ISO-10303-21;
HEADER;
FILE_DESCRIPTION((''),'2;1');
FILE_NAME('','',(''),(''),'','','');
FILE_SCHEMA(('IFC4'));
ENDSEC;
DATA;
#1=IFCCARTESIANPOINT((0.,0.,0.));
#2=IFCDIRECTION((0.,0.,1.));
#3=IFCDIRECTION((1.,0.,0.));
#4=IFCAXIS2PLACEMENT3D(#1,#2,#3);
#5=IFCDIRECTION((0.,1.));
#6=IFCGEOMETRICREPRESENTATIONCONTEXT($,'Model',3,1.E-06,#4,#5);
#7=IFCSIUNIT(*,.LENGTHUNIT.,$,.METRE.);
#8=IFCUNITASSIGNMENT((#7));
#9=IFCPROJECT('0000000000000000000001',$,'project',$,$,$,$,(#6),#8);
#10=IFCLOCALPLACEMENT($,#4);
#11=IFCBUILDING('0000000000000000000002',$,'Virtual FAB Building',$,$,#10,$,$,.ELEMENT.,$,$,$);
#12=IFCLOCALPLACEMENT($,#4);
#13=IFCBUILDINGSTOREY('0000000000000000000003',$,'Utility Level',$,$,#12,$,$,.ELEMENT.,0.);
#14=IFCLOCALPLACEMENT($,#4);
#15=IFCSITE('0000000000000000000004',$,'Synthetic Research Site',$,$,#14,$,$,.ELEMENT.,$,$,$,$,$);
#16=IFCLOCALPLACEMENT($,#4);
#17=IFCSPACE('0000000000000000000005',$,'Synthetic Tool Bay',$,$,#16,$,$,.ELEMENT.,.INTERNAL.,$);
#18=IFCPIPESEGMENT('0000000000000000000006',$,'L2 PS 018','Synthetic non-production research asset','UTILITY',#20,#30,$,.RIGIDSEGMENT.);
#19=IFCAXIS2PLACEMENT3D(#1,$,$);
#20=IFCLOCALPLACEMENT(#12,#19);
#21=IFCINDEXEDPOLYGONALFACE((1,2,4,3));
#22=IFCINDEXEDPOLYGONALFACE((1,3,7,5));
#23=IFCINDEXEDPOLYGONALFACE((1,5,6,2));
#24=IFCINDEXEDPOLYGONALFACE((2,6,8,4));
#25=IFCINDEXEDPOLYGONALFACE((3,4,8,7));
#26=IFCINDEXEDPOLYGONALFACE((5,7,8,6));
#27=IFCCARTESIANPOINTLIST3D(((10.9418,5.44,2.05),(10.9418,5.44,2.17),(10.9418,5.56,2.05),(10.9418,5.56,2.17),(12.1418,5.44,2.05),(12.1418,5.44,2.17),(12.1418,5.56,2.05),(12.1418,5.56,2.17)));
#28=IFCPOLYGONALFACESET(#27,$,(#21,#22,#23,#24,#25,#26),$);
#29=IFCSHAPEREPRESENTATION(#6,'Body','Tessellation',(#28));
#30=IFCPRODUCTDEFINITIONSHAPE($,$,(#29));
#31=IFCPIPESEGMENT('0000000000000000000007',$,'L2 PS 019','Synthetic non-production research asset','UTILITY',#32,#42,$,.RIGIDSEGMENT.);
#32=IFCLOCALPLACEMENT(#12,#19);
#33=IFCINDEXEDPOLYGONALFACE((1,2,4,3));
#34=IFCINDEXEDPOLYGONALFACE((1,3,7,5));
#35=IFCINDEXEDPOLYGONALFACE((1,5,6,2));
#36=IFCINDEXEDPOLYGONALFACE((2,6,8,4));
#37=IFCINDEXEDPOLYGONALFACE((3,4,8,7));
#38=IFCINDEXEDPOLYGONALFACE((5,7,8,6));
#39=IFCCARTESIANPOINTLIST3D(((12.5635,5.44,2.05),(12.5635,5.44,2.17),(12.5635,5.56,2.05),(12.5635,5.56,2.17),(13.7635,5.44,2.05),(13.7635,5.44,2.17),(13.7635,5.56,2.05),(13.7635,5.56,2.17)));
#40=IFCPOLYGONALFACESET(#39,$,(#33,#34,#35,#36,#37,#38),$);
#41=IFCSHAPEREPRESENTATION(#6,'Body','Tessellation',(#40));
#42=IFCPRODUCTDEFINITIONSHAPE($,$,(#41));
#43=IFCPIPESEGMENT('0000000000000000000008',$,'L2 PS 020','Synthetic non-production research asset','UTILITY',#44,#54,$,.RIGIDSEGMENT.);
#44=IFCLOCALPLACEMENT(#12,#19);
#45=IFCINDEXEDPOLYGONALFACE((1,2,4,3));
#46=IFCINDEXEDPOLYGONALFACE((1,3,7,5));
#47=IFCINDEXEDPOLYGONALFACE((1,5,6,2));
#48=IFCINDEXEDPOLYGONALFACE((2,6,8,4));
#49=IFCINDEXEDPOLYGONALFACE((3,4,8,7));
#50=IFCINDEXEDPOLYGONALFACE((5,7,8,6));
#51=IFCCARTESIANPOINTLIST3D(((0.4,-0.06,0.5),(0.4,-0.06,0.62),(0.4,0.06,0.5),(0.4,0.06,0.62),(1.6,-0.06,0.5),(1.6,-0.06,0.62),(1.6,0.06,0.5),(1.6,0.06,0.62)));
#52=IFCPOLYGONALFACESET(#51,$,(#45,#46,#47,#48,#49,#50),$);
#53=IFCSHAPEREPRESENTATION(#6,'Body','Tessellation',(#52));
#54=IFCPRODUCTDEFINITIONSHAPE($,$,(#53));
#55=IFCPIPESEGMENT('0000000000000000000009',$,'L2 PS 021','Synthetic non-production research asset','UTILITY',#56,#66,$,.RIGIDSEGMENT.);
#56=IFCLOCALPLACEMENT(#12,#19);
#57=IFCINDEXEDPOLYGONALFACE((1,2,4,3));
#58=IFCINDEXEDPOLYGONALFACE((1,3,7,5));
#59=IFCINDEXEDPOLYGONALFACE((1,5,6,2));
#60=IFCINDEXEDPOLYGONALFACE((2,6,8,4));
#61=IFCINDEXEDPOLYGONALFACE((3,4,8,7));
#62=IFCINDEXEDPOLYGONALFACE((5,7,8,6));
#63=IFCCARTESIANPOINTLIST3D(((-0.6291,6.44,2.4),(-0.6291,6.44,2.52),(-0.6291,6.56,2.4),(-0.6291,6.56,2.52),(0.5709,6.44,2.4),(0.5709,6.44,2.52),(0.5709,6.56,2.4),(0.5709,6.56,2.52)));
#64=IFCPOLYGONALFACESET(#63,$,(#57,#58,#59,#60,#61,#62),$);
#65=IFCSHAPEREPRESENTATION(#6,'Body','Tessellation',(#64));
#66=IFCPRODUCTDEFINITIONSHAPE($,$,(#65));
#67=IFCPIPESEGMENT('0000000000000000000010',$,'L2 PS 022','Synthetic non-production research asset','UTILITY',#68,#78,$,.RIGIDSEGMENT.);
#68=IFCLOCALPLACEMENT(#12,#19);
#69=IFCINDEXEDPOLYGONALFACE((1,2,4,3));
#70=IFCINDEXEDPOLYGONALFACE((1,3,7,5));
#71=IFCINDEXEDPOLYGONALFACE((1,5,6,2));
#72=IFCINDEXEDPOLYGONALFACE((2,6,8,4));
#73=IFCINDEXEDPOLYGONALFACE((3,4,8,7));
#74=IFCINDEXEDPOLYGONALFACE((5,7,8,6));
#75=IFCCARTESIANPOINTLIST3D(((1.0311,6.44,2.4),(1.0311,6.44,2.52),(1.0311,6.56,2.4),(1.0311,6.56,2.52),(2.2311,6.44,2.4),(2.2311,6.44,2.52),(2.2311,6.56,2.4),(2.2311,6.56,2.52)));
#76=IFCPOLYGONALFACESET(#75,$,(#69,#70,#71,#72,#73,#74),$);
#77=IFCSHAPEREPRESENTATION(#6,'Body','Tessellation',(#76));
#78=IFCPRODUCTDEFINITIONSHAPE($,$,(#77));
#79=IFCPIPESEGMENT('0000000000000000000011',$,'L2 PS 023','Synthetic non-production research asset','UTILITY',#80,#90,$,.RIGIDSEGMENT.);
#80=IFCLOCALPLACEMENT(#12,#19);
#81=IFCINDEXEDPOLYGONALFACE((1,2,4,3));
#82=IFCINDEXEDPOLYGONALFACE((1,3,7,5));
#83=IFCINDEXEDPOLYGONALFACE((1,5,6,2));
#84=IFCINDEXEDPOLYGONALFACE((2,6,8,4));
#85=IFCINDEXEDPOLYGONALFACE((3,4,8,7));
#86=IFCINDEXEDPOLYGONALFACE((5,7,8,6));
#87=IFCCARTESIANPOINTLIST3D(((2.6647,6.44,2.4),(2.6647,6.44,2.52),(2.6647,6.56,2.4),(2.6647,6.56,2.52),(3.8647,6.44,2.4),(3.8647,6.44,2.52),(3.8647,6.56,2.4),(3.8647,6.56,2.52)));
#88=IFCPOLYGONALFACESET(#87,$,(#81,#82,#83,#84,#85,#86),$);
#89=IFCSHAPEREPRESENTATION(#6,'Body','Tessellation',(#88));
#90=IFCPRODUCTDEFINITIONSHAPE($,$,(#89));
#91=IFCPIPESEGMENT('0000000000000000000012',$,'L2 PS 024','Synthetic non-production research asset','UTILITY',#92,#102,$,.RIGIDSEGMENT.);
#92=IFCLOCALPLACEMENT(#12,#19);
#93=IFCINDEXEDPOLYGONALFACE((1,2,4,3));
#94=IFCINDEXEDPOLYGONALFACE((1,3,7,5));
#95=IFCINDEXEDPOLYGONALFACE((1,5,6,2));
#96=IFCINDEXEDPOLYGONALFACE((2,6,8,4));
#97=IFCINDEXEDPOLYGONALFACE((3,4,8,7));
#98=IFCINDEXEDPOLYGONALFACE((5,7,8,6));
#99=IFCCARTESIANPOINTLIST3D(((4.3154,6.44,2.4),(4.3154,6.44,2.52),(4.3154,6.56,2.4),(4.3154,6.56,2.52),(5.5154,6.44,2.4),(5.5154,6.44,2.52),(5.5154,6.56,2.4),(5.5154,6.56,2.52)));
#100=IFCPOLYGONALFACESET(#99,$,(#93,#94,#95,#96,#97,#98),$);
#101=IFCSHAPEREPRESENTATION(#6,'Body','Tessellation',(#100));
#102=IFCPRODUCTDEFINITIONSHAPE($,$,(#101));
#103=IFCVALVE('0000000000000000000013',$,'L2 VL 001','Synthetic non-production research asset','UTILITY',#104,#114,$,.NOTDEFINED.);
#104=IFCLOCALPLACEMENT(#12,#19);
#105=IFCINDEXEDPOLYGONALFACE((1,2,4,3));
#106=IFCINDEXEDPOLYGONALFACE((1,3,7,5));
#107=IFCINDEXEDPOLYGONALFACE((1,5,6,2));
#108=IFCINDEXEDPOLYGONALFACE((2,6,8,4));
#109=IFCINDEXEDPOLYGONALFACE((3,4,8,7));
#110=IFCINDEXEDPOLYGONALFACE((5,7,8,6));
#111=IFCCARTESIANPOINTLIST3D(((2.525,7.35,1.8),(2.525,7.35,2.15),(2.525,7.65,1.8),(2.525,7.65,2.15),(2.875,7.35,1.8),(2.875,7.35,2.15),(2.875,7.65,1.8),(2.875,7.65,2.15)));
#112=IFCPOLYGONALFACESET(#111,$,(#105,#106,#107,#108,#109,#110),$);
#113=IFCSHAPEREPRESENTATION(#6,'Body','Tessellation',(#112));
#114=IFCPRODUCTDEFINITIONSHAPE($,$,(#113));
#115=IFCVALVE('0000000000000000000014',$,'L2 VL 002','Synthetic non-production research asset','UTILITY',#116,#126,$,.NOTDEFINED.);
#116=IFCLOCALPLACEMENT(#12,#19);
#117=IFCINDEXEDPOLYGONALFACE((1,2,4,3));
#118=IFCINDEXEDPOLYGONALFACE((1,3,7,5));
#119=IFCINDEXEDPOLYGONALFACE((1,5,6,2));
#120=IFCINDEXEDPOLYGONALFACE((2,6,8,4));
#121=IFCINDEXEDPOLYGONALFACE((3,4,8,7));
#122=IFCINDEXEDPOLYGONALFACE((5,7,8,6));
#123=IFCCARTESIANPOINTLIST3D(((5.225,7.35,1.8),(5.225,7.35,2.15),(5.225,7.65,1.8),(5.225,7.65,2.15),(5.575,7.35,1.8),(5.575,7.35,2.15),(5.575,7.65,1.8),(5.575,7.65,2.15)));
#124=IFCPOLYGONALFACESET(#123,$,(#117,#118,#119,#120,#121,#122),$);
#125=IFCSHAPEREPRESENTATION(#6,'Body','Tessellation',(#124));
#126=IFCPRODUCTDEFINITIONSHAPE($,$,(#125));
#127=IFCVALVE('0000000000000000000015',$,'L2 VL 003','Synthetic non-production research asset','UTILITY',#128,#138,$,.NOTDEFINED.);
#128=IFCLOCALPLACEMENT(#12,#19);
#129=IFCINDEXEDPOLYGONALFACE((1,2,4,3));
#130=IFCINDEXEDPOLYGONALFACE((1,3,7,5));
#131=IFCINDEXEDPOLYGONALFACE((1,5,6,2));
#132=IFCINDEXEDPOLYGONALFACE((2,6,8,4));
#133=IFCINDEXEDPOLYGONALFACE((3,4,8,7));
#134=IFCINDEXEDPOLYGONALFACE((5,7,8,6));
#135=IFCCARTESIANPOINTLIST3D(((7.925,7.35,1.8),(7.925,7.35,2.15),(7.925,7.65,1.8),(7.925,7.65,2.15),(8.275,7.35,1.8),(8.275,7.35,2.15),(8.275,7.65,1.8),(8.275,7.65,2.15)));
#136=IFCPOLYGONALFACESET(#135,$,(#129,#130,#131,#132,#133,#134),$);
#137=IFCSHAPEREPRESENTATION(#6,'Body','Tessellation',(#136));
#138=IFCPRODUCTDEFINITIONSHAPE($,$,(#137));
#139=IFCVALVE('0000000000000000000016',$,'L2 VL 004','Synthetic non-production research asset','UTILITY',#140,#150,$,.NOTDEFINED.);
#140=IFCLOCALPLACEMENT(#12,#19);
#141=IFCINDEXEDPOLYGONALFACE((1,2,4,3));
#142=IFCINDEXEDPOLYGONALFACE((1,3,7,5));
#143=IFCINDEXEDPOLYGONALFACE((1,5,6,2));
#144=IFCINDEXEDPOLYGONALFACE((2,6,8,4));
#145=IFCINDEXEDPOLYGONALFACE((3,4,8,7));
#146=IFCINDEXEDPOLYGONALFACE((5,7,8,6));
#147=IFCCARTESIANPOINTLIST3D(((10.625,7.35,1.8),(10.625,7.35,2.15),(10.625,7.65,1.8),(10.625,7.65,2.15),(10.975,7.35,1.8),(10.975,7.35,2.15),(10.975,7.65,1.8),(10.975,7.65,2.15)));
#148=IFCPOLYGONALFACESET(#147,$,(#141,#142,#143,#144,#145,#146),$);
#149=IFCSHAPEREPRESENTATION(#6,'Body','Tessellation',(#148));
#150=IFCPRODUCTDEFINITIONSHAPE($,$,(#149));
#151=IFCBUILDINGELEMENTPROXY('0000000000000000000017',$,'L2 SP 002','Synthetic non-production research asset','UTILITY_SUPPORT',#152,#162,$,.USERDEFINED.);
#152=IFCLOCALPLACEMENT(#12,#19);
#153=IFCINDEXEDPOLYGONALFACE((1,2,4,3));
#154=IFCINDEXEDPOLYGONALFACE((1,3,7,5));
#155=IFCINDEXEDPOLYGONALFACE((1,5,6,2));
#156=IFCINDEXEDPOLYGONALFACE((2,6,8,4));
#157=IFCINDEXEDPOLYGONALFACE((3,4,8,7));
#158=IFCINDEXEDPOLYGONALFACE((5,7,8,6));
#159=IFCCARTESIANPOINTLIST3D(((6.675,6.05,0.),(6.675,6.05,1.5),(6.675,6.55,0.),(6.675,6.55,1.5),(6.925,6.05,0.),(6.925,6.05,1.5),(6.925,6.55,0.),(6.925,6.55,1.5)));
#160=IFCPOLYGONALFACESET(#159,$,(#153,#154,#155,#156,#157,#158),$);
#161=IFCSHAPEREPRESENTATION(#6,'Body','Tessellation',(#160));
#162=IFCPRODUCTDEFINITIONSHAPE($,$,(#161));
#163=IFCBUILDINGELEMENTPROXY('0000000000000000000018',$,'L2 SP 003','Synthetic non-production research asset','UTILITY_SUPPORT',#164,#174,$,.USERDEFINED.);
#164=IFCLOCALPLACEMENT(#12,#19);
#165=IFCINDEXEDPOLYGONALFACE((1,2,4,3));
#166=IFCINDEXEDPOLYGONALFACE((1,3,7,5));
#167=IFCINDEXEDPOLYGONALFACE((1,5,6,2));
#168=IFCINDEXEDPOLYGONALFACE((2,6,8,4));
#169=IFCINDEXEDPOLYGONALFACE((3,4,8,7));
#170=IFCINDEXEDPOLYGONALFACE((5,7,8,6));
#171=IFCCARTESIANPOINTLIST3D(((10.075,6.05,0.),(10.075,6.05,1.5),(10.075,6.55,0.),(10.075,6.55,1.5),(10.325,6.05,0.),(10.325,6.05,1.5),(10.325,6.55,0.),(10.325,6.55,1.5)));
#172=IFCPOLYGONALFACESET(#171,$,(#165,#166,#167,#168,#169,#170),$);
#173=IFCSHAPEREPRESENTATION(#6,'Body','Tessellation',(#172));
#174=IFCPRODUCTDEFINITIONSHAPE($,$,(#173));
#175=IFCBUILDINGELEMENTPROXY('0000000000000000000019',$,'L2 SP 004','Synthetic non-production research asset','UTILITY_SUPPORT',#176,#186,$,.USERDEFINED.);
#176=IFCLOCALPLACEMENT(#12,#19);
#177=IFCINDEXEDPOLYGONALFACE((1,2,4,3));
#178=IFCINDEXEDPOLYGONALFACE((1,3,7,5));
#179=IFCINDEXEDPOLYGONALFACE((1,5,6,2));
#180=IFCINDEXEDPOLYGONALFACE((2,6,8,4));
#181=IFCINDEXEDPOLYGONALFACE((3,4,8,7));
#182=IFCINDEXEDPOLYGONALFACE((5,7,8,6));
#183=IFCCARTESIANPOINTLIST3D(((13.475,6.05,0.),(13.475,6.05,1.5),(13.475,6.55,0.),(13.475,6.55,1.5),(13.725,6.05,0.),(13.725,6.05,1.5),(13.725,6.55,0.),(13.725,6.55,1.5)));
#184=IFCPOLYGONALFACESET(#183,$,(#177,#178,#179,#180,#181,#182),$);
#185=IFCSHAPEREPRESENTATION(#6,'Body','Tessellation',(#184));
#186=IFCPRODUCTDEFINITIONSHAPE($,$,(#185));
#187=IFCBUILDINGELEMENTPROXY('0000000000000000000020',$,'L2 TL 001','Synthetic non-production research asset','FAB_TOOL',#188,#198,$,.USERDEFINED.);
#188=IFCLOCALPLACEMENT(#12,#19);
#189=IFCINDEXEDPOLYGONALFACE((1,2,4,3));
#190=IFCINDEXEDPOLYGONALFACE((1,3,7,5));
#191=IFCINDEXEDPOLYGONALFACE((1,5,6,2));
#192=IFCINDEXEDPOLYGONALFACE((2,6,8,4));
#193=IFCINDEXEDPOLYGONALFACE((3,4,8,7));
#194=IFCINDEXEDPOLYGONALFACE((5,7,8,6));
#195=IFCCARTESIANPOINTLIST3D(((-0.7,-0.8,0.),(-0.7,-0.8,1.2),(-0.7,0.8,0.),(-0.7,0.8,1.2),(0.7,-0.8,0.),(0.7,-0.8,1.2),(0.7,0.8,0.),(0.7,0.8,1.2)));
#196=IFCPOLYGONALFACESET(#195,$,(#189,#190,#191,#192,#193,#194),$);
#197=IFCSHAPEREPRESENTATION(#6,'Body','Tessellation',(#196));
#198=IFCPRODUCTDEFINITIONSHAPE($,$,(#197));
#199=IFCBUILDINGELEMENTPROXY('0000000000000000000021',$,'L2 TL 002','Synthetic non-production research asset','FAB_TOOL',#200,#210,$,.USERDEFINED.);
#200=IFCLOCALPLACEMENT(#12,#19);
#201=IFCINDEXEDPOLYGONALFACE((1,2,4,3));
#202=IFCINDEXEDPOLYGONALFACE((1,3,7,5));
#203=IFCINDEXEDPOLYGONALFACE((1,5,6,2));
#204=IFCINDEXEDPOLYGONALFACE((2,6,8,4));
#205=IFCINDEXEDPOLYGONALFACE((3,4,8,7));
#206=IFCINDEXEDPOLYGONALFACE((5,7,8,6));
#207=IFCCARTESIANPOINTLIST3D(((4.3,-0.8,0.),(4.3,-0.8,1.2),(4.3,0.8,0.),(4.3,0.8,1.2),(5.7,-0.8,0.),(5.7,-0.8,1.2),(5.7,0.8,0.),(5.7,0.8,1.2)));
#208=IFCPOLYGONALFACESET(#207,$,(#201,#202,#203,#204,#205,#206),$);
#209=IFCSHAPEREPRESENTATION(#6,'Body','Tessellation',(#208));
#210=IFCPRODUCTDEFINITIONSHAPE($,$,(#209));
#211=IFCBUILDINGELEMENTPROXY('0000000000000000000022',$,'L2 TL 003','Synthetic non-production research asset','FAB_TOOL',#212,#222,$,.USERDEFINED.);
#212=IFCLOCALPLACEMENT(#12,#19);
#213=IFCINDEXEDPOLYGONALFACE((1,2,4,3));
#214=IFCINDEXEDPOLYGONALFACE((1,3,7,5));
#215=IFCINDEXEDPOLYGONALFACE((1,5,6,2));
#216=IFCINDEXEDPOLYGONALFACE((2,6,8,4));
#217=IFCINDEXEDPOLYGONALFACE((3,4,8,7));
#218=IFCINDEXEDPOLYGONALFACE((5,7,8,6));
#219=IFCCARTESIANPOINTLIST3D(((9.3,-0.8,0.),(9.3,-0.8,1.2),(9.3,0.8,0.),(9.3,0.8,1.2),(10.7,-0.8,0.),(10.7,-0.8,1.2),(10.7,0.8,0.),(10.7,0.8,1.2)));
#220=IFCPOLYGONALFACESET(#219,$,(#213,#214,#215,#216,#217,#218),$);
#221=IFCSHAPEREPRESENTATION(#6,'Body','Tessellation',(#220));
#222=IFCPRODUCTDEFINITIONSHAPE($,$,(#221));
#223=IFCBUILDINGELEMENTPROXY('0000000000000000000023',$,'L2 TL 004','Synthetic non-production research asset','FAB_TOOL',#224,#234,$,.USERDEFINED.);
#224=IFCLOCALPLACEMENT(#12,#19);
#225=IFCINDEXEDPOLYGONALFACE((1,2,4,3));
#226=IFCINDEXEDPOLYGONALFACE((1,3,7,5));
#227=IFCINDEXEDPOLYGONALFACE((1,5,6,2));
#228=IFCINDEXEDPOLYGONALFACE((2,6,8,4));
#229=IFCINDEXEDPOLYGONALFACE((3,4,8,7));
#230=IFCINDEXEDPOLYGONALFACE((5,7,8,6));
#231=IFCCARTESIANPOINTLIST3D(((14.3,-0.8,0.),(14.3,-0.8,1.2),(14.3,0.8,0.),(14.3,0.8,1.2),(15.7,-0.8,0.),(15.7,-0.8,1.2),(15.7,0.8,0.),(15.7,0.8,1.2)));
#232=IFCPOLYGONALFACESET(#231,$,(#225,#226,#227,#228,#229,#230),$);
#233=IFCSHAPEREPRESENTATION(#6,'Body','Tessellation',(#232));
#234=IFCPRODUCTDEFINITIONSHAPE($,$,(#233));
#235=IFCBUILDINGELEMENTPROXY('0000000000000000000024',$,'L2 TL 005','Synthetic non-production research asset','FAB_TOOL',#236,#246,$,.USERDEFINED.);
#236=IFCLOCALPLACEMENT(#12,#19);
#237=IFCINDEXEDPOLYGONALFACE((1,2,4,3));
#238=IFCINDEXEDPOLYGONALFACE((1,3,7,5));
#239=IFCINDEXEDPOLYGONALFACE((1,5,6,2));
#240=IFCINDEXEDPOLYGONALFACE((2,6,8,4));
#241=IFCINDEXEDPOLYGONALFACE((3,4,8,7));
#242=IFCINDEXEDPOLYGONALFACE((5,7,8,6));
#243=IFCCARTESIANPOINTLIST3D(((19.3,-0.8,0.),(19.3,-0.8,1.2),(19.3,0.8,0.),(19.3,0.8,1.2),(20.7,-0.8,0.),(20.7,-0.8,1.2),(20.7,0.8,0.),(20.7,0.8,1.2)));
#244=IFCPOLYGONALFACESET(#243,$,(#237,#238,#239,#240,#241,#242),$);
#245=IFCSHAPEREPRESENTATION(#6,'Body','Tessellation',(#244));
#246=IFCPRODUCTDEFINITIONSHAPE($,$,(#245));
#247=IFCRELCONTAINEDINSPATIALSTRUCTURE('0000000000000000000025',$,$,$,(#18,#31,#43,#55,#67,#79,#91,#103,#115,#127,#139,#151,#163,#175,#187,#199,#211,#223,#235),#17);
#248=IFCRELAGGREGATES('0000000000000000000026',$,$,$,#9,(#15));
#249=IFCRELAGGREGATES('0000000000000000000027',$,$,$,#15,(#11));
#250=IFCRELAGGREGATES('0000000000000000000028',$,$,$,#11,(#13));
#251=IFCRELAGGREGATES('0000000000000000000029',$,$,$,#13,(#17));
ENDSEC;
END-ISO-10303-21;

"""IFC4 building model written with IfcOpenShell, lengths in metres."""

from ifc_helpers import new_model, si_unit, direction, frame, origin_with_axes, origin_2d_with_axis, place, context, project, spatial, rectangle, extrude, element, save


model = new_model("IFC4")

# Units and contexts
model_context = context("Model", 3, precision=1e-06, world=origin_with_axes(), true_north=direction((0.0, 1.0)))
ifc_project = project(units=[si_unit("LENGTHUNIT", "METRE")], contexts=[model_context])

# Site, building, storey, space
site_placement = place(None, origin_with_axes())
site = spatial("IfcSite", under=ifc_project, at=site_placement, Name="Synthetic Research Site", CompositionType="ELEMENT")
building_placement = place(None, origin_with_axes())
building = spatial("IfcBuilding", under=site, at=building_placement, Name="Virtual FAB Building", CompositionType="ELEMENT")
storey_placement = place(None, origin_with_axes())
storey = spatial("IfcBuildingStorey", under=building, at=storey_placement, Name="Utility Level", CompositionType="ELEMENT", Elevation=0.0)
space_placement = place(None, origin_with_axes())
space = spatial("IfcSpace", under=storey, at=space_placement, Name="Synthetic Tool Bay", CompositionType="ELEMENT", PredefinedType="INTERNAL")

# Pipe segments
for number, where, z_axis, x_axis, name in (
    (1, (11.5418, 5.5, 2.05), (0.0, 0.0, 1.0), (1.0, 0.0, 0.0), "L2 PS 018"),
    (2, (13.1635, 5.5, 2.05), (0.0, 0.0, 1.0), (1.0, 0.0, 0.0), "L2 PS 019"),
    (3, (1.0, 0.0, 0.5), (0.0, 0.0, 1.0), (1.0, 0.0, 0.0), "L2 PS 020"),
    (4, (-0.0291, 6.5, 2.4), (0.0, 0.0, 1.0), (1.0, 0.0, 0.0), "L2 PS 021"),
    (5, (1.6311, 6.5, 2.4), (0.0, 0.0, 1.0), (1.0, 0.0, 0.0), "L2 PS 022"),
    (6, (3.2647, 6.5, 2.4), (0.0, 0.0, 1.0), (1.0, 0.0, 0.0), "L2 PS 023"),
    (7, (4.9154, 6.5, 2.4), (0.0, 0.0, 1.0), (1.0, 0.0, 0.0), "L2 PS 024"),
):
    element("IfcPipeSegment", number, at=place(None, frame(where, z_axis=z_axis, x_axis=x_axis)), inside=space, Name=name, Description="Synthetic non-production research asset", ObjectType="UTILITY", PredefinedType="RIGIDSEGMENT", context=model_context, shape_type="SweptSolid", body=[
        extrude(rectangle(XDim=1.2, YDim=0.12, at=origin_2d_with_axis()), origin_with_axes(), (0.0, 0.0, 1.0), 0.12),
    ])

# Valves
for number, where, z_axis, x_axis, name in (
    (8, (2.7, 7.5, 1.8), (0.0, 0.0, 1.0), (1.0, 0.0, 0.0), "L2 VL 001"),
    (9, (5.4, 7.5, 1.8), (0.0, 0.0, 1.0), (1.0, 0.0, 0.0), "L2 VL 002"),
    (10, (8.1, 7.5, 1.8), (0.0, 0.0, 1.0), (1.0, 0.0, 0.0), "L2 VL 003"),
    (11, (10.8, 7.5, 1.8), (0.0, 0.0, 1.0), (1.0, 0.0, 0.0), "L2 VL 004"),
):
    element("IfcValve", number, at=place(None, frame(where, z_axis=z_axis, x_axis=x_axis)), inside=space, Name=name, Description="Synthetic non-production research asset", ObjectType="UTILITY", PredefinedType="NOTDEFINED", context=model_context, shape_type="SweptSolid", body=[
        extrude(rectangle(XDim=0.35, YDim=0.3, at=origin_2d_with_axis()), origin_with_axes(), (0.0, 0.0, 1.0), 0.35),
    ])

# Building element proxies
for number, where, z_axis, x_axis, name in (
    (12, (6.8, 6.3, 0.0), (0.0, 0.0, 1.0), (1.0, 0.0, 0.0), "L2 SP 002"),
    (13, (10.2, 6.3, 0.0), (0.0, 0.0, 1.0), (1.0, 0.0, 0.0), "L2 SP 003"),
    (14, (13.6, 6.3, 0.0), (0.0, 0.0, 1.0), (1.0, 0.0, 0.0), "L2 SP 004"),
):
    element("IfcBuildingElementProxy", number, at=place(None, frame(where, z_axis=z_axis, x_axis=x_axis)), inside=space, Name=name, Description="Synthetic non-production research asset", ObjectType="UTILITY_SUPPORT", PredefinedType="USERDEFINED", context=model_context, shape_type="SweptSolid", body=[
        extrude(rectangle(XDim=0.25, YDim=0.5, at=origin_2d_with_axis()), origin_with_axes(), (0.0, 0.0, 1.0), 1.5),
    ])
for number, where, z_axis, x_axis, name in (
    (15, (0.0, 0.0, 0.0), (0.0, 0.0, 1.0), (1.0, 0.0, 0.0), "L2 TL 001"),
    (16, (5.0, 0.0, 0.0), (0.0, 0.0, 1.0), (1.0, 0.0, 0.0), "L2 TL 002"),
    (17, (10.0, 0.0, 0.0), (0.0, 0.0, 1.0), (1.0, 0.0, 0.0), "L2 TL 003"),
    (18, (15.0, 0.0, 0.0), (0.0, 0.0, 1.0), (1.0, 0.0, 0.0), "L2 TL 004"),
    (19, (20.0, 0.0, 0.0), (0.0, 0.0, 1.0), (1.0, 0.0, 0.0), "L2 TL 005"),
):
    element("IfcBuildingElementProxy", number, at=place(None, frame(where, z_axis=z_axis, x_axis=x_axis)), inside=space, Name=name, Description="Synthetic non-production research asset", ObjectType="FAB_TOOL", PredefinedType="USERDEFINED", context=model_context, shape_type="SweptSolid", body=[
        extrude(rectangle(XDim=1.4, YDim=1.6, at=origin_2d_with_axis()), origin_with_axes(), (0.0, 0.0, 1.0), 1.2),
    ])

save(model, "model.ifc")
